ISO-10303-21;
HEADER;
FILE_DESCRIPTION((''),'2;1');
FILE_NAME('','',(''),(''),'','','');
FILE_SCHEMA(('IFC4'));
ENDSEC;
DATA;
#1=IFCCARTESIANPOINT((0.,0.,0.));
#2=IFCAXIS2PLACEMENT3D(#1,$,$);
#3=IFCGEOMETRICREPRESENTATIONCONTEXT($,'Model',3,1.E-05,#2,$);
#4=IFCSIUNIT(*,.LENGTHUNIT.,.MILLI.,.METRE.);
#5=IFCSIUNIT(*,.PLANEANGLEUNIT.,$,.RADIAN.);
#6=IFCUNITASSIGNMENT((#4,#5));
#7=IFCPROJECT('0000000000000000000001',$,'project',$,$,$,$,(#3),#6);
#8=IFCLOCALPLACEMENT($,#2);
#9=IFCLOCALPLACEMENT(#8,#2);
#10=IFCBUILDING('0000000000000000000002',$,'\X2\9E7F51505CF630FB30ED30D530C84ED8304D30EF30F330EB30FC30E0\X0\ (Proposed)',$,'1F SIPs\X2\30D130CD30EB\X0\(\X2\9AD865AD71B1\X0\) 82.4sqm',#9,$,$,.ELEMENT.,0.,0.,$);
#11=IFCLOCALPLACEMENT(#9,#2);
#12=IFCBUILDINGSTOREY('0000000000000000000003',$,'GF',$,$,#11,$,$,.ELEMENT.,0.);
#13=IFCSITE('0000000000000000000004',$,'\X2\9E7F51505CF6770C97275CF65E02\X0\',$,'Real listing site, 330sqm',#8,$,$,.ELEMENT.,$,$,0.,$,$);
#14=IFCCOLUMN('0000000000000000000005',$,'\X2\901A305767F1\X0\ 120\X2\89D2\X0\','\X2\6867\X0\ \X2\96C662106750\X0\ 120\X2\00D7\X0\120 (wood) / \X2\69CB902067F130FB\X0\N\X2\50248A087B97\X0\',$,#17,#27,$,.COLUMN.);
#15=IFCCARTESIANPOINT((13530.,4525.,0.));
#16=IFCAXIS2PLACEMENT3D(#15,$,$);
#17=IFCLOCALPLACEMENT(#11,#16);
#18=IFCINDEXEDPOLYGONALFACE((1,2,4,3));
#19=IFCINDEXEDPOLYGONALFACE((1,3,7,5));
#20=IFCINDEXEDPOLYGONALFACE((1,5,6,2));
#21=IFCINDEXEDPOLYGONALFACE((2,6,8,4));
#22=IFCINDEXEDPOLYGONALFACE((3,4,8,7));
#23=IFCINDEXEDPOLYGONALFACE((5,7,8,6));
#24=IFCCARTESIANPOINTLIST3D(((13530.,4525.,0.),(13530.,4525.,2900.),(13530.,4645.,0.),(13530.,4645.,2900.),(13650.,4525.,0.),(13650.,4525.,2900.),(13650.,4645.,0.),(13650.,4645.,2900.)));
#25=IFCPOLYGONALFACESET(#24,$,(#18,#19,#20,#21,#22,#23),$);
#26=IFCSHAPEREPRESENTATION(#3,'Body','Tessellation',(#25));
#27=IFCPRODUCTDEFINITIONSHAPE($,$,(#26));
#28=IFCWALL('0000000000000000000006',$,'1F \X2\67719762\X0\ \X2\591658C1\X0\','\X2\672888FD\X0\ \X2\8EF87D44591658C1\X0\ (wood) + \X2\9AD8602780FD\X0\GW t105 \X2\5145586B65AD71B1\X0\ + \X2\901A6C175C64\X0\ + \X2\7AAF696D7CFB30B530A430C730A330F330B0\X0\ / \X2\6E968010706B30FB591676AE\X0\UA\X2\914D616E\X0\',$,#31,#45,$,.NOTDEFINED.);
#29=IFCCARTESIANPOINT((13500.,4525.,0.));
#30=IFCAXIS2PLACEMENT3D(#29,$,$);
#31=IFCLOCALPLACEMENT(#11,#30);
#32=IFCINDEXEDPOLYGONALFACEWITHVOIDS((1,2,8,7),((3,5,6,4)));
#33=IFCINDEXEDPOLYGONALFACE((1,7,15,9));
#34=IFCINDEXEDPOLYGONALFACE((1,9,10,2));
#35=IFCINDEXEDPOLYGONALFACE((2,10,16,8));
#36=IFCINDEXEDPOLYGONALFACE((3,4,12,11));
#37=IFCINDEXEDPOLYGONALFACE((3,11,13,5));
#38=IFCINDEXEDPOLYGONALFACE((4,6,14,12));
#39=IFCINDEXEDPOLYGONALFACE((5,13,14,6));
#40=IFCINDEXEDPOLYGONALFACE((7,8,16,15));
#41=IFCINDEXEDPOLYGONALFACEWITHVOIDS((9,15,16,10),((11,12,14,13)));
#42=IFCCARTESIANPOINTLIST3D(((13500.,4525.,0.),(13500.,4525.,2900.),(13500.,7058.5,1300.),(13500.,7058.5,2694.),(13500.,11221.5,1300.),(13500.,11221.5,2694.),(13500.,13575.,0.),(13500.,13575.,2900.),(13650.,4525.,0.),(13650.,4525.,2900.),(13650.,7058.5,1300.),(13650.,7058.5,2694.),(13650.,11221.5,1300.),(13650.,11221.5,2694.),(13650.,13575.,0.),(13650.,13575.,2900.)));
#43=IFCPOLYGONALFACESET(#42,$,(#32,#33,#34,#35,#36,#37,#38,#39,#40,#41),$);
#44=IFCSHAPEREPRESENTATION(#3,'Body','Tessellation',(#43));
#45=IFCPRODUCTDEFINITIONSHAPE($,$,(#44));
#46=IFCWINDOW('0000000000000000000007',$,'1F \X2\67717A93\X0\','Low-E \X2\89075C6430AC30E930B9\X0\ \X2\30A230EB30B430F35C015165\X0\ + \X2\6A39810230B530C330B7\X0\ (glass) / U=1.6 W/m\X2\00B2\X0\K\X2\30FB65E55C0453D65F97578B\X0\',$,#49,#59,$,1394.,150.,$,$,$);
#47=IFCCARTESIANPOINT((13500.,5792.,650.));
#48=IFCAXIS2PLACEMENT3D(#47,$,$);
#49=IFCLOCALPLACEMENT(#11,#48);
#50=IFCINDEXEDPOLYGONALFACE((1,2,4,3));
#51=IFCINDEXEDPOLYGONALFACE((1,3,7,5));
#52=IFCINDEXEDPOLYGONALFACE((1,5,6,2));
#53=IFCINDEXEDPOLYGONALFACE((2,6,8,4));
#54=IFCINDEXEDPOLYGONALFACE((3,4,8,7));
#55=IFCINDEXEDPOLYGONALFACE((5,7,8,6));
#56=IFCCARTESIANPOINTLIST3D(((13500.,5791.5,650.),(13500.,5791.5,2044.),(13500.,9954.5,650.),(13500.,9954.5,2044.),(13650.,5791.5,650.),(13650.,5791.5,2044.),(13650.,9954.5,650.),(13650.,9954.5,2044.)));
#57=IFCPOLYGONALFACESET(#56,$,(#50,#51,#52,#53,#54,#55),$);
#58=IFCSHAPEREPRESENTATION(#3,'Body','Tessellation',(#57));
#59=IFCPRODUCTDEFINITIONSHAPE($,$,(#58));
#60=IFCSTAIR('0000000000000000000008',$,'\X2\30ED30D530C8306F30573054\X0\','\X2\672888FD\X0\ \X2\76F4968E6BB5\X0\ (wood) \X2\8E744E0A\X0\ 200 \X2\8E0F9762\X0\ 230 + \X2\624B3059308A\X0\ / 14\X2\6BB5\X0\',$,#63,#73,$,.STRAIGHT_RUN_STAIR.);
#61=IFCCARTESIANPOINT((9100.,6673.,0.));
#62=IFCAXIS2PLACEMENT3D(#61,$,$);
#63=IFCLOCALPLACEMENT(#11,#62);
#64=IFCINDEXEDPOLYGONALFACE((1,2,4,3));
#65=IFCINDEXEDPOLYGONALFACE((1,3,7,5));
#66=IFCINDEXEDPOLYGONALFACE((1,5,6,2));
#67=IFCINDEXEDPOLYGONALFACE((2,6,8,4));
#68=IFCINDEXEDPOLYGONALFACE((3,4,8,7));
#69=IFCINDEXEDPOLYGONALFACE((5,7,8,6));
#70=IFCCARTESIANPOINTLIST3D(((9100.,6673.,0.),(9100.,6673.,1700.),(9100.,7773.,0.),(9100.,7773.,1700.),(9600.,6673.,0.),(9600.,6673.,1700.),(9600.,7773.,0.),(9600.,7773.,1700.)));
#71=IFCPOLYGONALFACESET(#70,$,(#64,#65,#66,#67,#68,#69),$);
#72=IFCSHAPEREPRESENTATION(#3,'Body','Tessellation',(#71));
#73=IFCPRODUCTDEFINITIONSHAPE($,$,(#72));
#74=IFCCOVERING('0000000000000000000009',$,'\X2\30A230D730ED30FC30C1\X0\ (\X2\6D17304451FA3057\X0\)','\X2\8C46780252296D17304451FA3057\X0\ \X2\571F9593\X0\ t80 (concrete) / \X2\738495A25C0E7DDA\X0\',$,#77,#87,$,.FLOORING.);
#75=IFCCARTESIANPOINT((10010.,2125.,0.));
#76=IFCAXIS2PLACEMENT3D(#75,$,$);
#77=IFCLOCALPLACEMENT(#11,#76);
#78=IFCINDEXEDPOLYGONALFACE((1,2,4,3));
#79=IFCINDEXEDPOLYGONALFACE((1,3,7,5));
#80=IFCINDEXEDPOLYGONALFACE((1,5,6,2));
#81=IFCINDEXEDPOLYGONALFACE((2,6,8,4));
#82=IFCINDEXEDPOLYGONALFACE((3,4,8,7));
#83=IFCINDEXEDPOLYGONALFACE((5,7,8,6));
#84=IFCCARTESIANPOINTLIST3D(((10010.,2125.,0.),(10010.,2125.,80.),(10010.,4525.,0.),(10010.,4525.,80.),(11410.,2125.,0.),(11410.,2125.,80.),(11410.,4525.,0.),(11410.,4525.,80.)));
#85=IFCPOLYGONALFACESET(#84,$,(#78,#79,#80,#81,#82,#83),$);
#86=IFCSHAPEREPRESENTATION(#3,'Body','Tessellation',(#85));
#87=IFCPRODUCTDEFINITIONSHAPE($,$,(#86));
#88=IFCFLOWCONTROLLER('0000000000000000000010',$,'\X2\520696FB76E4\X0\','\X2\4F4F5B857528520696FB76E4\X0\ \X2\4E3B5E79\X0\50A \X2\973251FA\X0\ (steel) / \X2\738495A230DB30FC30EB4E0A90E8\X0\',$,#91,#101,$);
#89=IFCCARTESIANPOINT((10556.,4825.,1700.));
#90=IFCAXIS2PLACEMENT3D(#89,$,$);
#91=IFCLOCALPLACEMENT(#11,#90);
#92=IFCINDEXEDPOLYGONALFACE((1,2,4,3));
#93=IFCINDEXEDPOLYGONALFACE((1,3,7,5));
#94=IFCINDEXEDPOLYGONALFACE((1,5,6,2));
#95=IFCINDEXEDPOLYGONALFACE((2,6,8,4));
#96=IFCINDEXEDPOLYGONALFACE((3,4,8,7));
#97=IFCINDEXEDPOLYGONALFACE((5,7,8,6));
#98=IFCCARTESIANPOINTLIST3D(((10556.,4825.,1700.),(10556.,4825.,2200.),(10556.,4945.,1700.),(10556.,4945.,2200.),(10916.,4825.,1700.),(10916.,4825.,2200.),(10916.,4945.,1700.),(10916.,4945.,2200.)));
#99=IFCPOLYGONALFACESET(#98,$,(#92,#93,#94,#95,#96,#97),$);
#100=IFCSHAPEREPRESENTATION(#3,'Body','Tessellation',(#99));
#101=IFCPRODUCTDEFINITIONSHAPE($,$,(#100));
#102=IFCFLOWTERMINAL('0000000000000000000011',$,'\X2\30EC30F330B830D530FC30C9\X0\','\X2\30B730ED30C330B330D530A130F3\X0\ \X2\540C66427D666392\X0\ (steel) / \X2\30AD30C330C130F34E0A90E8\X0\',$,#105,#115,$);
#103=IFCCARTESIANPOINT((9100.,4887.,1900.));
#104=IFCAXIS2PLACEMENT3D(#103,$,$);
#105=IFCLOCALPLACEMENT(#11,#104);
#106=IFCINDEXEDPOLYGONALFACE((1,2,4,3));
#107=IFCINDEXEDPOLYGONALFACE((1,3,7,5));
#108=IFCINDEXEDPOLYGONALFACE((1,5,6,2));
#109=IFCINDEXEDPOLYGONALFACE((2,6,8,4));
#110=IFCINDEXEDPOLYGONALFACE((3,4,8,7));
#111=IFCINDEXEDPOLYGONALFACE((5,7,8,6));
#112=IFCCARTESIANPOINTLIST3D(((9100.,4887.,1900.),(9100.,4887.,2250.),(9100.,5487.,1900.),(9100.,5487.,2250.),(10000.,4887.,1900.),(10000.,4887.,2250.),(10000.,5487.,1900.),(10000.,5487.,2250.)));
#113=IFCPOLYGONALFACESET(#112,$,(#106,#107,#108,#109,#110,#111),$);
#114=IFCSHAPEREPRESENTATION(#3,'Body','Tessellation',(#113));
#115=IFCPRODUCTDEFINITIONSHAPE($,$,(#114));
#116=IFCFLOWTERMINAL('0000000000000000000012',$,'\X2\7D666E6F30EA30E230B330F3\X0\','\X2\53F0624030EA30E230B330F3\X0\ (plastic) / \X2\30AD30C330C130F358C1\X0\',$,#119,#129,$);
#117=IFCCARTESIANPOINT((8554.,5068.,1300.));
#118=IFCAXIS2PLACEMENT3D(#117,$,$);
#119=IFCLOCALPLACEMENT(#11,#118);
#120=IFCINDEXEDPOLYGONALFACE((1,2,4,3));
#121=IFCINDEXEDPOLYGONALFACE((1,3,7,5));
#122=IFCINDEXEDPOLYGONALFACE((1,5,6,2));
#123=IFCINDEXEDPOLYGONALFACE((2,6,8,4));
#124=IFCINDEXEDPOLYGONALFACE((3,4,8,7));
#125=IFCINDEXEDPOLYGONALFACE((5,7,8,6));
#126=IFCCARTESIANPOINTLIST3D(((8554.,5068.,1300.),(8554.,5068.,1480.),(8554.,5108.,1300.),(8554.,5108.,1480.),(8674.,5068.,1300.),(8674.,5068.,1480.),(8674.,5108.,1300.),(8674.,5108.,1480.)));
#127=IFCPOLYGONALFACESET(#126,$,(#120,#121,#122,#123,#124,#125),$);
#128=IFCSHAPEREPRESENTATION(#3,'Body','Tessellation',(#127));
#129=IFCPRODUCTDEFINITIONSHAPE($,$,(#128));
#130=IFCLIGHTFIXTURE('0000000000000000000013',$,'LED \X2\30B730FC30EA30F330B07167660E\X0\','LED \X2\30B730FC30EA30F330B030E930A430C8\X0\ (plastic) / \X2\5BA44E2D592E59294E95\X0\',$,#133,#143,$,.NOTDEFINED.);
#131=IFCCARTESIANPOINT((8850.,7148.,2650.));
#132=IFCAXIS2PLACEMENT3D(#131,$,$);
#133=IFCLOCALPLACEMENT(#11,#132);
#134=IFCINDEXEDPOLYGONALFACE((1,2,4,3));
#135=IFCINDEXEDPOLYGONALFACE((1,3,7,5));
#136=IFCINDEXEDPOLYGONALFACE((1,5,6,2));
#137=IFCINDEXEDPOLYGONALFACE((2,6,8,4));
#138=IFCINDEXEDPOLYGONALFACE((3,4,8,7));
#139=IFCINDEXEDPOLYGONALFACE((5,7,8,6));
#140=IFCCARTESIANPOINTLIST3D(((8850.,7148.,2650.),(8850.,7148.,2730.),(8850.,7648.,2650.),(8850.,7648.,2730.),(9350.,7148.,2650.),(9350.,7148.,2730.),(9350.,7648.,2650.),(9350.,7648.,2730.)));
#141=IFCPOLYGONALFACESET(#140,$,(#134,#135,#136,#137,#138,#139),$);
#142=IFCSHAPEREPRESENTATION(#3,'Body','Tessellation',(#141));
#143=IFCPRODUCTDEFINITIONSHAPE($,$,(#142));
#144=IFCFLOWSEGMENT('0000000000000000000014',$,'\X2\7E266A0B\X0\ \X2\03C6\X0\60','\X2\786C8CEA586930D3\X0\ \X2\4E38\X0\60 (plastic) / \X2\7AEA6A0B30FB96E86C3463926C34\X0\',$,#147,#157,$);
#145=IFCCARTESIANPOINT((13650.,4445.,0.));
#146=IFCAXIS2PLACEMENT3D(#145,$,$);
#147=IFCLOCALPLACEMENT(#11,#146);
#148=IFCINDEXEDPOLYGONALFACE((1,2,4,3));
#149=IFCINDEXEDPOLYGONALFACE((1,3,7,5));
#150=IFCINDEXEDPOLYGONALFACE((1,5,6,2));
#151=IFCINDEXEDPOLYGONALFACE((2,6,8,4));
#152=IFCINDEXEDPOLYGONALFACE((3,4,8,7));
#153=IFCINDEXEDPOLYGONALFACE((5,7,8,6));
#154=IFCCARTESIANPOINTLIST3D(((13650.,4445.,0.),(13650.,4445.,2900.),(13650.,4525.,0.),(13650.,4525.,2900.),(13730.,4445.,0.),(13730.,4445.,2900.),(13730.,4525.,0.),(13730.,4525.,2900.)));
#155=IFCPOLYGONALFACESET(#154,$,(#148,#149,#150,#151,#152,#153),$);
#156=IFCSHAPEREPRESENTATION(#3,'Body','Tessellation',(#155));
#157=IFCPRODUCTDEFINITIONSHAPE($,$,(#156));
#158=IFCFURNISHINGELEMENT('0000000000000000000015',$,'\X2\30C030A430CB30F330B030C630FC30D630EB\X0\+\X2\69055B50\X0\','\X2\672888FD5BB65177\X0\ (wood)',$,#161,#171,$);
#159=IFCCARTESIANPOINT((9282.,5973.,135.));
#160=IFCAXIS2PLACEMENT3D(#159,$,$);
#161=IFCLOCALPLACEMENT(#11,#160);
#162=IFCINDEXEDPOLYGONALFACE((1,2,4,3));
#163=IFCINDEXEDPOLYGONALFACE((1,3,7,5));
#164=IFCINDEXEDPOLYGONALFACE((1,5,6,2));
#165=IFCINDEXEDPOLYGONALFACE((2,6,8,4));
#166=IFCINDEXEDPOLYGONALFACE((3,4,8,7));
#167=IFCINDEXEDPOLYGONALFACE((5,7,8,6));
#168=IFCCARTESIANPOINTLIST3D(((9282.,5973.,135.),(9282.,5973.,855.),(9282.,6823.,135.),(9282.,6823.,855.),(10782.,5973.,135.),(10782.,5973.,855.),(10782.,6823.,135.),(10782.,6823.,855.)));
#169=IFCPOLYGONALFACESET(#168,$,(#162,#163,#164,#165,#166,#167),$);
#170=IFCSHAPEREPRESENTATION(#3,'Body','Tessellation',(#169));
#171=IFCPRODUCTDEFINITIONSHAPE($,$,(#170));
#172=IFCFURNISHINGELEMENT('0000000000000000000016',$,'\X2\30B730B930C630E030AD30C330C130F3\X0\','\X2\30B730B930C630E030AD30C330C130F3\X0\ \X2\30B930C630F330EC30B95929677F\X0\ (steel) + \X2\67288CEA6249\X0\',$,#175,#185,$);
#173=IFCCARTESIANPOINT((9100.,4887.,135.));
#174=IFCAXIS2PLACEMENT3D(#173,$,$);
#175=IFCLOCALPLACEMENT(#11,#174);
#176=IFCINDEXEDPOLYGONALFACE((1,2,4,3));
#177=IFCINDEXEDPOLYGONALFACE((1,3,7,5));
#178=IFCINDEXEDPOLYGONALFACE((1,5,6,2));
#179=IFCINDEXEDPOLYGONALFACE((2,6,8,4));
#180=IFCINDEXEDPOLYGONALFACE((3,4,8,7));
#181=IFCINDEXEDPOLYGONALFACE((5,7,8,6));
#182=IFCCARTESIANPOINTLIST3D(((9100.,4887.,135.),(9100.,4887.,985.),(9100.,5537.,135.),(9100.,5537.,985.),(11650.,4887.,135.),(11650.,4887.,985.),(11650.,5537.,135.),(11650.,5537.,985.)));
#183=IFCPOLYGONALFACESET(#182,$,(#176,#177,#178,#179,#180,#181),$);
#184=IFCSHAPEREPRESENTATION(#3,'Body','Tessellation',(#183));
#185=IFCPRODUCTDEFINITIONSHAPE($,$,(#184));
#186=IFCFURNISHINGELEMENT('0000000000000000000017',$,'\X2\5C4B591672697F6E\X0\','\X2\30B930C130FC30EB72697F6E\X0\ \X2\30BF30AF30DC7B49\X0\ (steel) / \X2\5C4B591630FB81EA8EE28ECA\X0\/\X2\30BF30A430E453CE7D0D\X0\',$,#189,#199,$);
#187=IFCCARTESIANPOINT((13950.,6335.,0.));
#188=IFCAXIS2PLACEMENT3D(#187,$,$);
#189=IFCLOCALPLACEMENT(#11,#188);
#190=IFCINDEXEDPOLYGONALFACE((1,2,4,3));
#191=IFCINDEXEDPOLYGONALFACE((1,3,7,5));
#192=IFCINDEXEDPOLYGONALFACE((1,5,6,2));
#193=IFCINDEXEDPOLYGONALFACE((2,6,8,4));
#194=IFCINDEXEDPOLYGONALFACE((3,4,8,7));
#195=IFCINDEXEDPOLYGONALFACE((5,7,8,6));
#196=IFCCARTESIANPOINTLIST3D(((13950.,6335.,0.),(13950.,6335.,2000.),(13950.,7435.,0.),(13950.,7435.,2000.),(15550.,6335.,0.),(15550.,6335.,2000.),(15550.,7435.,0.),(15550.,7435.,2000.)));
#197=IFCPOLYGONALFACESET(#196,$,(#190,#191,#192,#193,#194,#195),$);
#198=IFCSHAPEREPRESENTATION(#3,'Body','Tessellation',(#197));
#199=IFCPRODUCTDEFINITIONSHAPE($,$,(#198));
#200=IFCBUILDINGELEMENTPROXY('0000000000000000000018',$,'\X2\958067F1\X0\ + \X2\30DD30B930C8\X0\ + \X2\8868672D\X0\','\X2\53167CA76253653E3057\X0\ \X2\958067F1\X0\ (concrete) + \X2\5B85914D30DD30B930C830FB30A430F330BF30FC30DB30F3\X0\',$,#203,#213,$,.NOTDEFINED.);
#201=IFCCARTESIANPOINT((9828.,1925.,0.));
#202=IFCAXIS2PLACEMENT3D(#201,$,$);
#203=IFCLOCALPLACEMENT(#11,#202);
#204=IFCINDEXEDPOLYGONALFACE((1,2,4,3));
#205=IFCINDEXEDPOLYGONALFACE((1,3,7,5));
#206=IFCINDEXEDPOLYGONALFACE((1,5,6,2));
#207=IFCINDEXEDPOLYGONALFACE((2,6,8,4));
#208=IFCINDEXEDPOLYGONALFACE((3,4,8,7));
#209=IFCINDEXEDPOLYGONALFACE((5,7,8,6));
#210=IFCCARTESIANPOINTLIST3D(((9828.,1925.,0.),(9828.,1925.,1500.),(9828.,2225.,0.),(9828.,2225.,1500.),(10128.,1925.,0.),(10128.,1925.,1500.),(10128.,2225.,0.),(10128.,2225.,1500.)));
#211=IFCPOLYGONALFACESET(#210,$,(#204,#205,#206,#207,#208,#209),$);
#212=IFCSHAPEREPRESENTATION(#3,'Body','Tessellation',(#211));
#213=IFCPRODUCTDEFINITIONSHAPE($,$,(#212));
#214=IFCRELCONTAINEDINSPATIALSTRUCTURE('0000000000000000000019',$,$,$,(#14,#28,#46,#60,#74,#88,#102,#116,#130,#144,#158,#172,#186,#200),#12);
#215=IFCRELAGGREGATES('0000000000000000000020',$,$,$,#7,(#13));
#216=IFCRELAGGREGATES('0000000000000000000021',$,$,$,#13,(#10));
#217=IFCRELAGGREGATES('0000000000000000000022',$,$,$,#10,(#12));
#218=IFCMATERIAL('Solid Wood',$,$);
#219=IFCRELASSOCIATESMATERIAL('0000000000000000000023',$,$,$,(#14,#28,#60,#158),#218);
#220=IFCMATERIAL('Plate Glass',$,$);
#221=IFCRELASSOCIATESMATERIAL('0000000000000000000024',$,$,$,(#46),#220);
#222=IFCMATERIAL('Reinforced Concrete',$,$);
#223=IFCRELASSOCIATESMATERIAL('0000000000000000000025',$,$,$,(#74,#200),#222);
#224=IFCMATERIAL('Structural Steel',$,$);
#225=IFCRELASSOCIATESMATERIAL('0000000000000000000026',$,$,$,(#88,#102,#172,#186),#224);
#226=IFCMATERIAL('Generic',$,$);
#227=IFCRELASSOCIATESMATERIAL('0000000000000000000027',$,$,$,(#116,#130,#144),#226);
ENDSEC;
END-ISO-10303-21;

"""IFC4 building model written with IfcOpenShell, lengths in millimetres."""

from ifc_helpers import new_model, si_unit, frame, frame_2d, origin, place, context, project, spatial, rectangle, extrude, material, element, fill, save


model = new_model("IFC4")

# Units and contexts
model_context = context("Model", 3, precision=1e-05, world=origin())
ifc_project = project(units=[si_unit("LENGTHUNIT", "METRE", prefix="MILLI"), si_unit("PLANEANGLEUNIT", "RADIAN")], contexts=[model_context])

# Site, building, storey
site_placement = place(None, origin())
site = spatial("IfcSite", under=ifc_project, at=site_placement, Name="鹿児島県霧島市", ObjectType="Real listing site, 330sqm", CompositionType="ELEMENT", RefElevation=0.0)
building_placement = place(site_placement, origin())
building = spatial("IfcBuilding", under=site, at=building_placement, Name="鹿児島・ロフト付きワンルーム (Proposed)", ObjectType="1F SIPsパネル(高断熱) 82.4sqm", CompositionType="ELEMENT", ElevationOfRefHeight=0.0, ElevationOfTerrain=0.0)
storey_placement = place(building_placement, origin())
storey = spatial("IfcBuildingStorey", under=building, at=storey_placement, Name="GF", CompositionType="ELEMENT", Elevation=0.0)

# Column
ifc_material_1 = material(Name="Solid Wood")
column_1_placement = place(storey_placement, frame((13530.0, 4525.0, 0.0)))
element("IfcColumn", 1, at=column_1_placement, inside=storey, material=ifc_material_1, Name="通し柱 120角", Description="桧 集成材 120×120 (wood) / 構造柱・N値計算", PredefinedType="COLUMN", context=model_context, shape_type="SweptSolid", body=[
    extrude(rectangle(XDim=120.0, YDim=120.0, at=frame_2d((60.0, 60.0))), frame((13530.0, 4525.0, 0.0)), (0.0, 0.0, 1.0), 2900.0),
])

# Wall, opening, window
wall_1_placement = place(storey_placement, frame((13500.0, 4525.0, 0.0)))
wall_1 = element("IfcWall", 2, at=wall_1_placement, inside=storey, material=ifc_material_1, Name="1F 東面 外壁", Description="木製 軸組外壁 (wood) + 高性能GW t105 充填断熱 + 通気層 + 窯業系サイディング / 準耐火・外皮UA配慮", PredefinedType="NOTDEFINED", context=model_context, shape_type="SweptSolid", body=[
    extrude(rectangle(XDim=150.0, YDim=9050.0, at=frame_2d((75.0, 4525.0))), frame((13500.0, 4525.0, 0.0)), (0.0, 0.0, 1.0), 2900.0),
])
opening_placement = place(storey_placement, frame((13500.0, 5792.0, 650.0)))
opening = element("IfcOpeningElement", 3, at=opening_placement, cuts=wall_1, PredefinedType="NOTDEFINED", context=model_context, shape_type="SweptSolid", body=[
    extrude(rectangle(XDim=150.0, YDim=4163.0, at=frame_2d((75.0, 2081.0))), frame((13500.0, 5792.0, 650.0)), (0.0, 0.0, 1.0), 1394.0),
])
ifc_material_2 = material(Name="Plate Glass")
window_placement = place(storey_placement, frame((13500.0, 5792.0, 650.0)))
window = element("IfcWindow", 4, at=window_placement, inside=storey, material=ifc_material_2, Name="1F 東窓", Description="Low-E 複層ガラス アルゴン封入 + 樹脂サッシ (glass) / U=1.6 W/m²K・日射取得型", OverallHeight=1394.0, OverallWidth=150.0, context=model_context, shape_type="SweptSolid", body=[
    extrude(rectangle(XDim=150.0, YDim=4163.0, at=frame_2d((75.0, 2081.0))), frame((13500.0, 5792.0, 650.0)), (0.0, 0.0, 1.0), 1394.0),
])
fill(opening, window)

# Stair
stair_placement = place(storey_placement, frame((9100.0, 6673.0, 0.0)))
element("IfcStair", 5, at=stair_placement, inside=storey, material=ifc_material_1, Name="ロフトはしご", Description="木製 直階段 (wood) 蹴上 200 踏面 230 + 手すり / 14段", PredefinedType="STRAIGHT_RUN_STAIR", context=model_context, shape_type="SweptSolid", body=[
    extrude(rectangle(XDim=500.0, YDim=1100.0, at=frame_2d((250.0, 550.0))), frame((9100.0, 6673.0, 0.0)), (0.0, 0.0, 1.0), 1700.0),
])

# Covering
ifc_material_3 = material(Name="Reinforced Concrete")
covering_placement = place(storey_placement, frame((10010.0, 2125.0, 0.0)))
element("IfcCovering", 6, at=covering_placement, inside=storey, material=ifc_material_3, Name="アプローチ (洗い出し)", Description="豆砂利洗い出し 土間 t80 (concrete) / 玄関導線", PredefinedType="FLOORING", context=model_context, shape_type="SweptSolid", body=[
    extrude(rectangle(XDim=1400.0, YDim=2400.0, at=frame_2d((700.0, 1200.0))), frame((10010.0, 2125.0, 0.0)), (0.0, 0.0, 1.0), 80.0),
])

# Flow controller
ifc_material_4 = material(Name="Structural Steel")
flow_controller_placement = place(storey_placement, frame((10556.0, 4825.0, 1700.0)))
element("IfcFlowController", 7, at=flow_controller_placement, inside=storey, material=ifc_material_4, Name="分電盤", Description="住宅用分電盤 主幹50A 露出 (steel) / 玄関ホール上部", context=model_context, shape_type="SweptSolid", body=[
    extrude(rectangle(XDim=360.0, YDim=120.0, at=frame_2d((180.0, 60.0))), frame((10556.0, 4825.0, 1700.0)), (0.0, 0.0, 1.0), 500.0),
])

# Flow terminals
flow_terminal_1_placement = place(storey_placement, frame((9100.0, 4887.0, 1900.0)))
element("IfcFlowTerminal", 8, at=flow_terminal_1_placement, inside=storey, material=ifc_material_4, Name="レンジフード", Description="シロッコファン 同時給排 (steel) / キッチン上部", context=model_context, shape_type="SweptSolid", body=[
    extrude(rectangle(XDim=900.0, YDim=600.0, at=frame_2d((450.0, 300.0))), frame((9100.0, 4887.0, 1900.0)), (0.0, 0.0, 1.0), 350.0),
])
ifc_material_5 = material(Name="Generic")
flow_terminal_2_placement = place(storey_placement, frame((8554.0, 5068.0, 1300.0)))
element("IfcFlowTerminal", 9, at=flow_terminal_2_placement, inside=storey, material=ifc_material_5, Name="給湯リモコン", Description="台所リモコン (plastic) / キッチン壁", context=model_context, shape_type="SweptSolid", body=[
    extrude(rectangle(XDim=120.0, YDim=40.0, at=frame_2d((60.0, 20.0))), frame((8554.0, 5068.0, 1300.0)), (0.0, 0.0, 1.0), 180.0),
])

# Light fixture
light_fixture_placement = place(storey_placement, frame((8850.0, 7148.0, 2650.0)))
element("IfcLightFixture", 10, at=light_fixture_placement, inside=storey, material=ifc_material_5, Name="LED シーリング照明", Description="LED シーリングライト (plastic) / 室中央天井", PredefinedType="NOTDEFINED", context=model_context, shape_type="SweptSolid", body=[
    extrude(rectangle(XDim=500.0, YDim=500.0, at=frame_2d((250.0, 250.0))), frame((8850.0, 7148.0, 2650.0)), (0.0, 0.0, 1.0), 80.0),
])

# Flow segment
flow_segment_placement = place(storey_placement, frame((13650.0, 4445.0, 0.0)))
element("IfcFlowSegment", 11, at=flow_segment_placement, inside=storey, material=ifc_material_5, Name="縦樋 φ60", Description="硬質塩ビ 丸60 (plastic) / 竪樋・雨水排水", context=model_context, shape_type="SweptSolid", body=[
    extrude(rectangle(XDim=80.0, YDim=80.0, at=frame_2d((40.0, 40.0))), frame((13650.0, 4445.0, 0.0)), (0.0, 0.0, 1.0), 2900.0),
])

# Furnishing elements
furnishing_1_placement = place(storey_placement, frame((9282.0, 5973.0, 135.0)))
element("IfcFurnishingElement", 12, at=furnishing_1_placement, inside=storey, material=ifc_material_1, Name="ダイニングテーブル+椅子", Description="木製家具 (wood)", context=model_context, shape_type="SweptSolid", body=[
    extrude(rectangle(XDim=1500.0, YDim=850.0, at=frame_2d((750.0, 425.0))), frame((9282.0, 5973.0, 135.0)), (0.0, 0.0, 1.0), 720.0),
])
furnishing_2_placement = place(storey_placement, frame((9100.0, 4887.0, 135.0)))
element("IfcFurnishingElement", 13, at=furnishing_2_placement, inside=storey, material=ifc_material_4, Name="システムキッチン", Description="システムキッチン ステンレス天板 (steel) + 木質扉", context=model_context, shape_type="SweptSolid", body=[
    extrude(rectangle(XDim=2550.0, YDim=650.0, at=frame_2d((1275.0, 325.0))), frame((9100.0, 4887.0, 135.0)), (0.0, 0.0, 1.0), 850.0),
])
furnishing_3_placement = place(storey_placement, frame((13950.0, 6335.0, 0.0)))
element("IfcFurnishingElement", 14, at=furnishing_3_placement, inside=storey, material=ifc_material_4, Name="屋外物置", Description="スチール物置 タクボ等 (steel) / 屋外・自転車/タイヤ収納", context=model_context, shape_type="SweptSolid", body=[
    extrude(rectangle(XDim=1600.0, YDim=1100.0, at=frame_2d((800.0, 550.0))), frame((13950.0, 6335.0, 0.0)), (0.0, 0.0, 1.0), 2000.0),
])

# Building element proxy
proxy_placement = place(storey_placement, frame((9828.0, 1925.0, 0.0)))
element("IfcBuildingElementProxy", 15, at=proxy_placement, inside=storey, material=ifc_material_3, Name="門柱 + ポスト + 表札", Description="化粧打放し 門柱 (concrete) + 宅配ポスト・インターホン", PredefinedType="NOTDEFINED", context=model_context, shape_type="SweptSolid", body=[
    extrude(rectangle(XDim=300.0, YDim=300.0, at=frame_2d((150.0, 150.0))), frame((9828.0, 1925.0, 0.0)), (0.0, 0.0, 1.0), 1500.0),
])

save(model, "model.ifc")
